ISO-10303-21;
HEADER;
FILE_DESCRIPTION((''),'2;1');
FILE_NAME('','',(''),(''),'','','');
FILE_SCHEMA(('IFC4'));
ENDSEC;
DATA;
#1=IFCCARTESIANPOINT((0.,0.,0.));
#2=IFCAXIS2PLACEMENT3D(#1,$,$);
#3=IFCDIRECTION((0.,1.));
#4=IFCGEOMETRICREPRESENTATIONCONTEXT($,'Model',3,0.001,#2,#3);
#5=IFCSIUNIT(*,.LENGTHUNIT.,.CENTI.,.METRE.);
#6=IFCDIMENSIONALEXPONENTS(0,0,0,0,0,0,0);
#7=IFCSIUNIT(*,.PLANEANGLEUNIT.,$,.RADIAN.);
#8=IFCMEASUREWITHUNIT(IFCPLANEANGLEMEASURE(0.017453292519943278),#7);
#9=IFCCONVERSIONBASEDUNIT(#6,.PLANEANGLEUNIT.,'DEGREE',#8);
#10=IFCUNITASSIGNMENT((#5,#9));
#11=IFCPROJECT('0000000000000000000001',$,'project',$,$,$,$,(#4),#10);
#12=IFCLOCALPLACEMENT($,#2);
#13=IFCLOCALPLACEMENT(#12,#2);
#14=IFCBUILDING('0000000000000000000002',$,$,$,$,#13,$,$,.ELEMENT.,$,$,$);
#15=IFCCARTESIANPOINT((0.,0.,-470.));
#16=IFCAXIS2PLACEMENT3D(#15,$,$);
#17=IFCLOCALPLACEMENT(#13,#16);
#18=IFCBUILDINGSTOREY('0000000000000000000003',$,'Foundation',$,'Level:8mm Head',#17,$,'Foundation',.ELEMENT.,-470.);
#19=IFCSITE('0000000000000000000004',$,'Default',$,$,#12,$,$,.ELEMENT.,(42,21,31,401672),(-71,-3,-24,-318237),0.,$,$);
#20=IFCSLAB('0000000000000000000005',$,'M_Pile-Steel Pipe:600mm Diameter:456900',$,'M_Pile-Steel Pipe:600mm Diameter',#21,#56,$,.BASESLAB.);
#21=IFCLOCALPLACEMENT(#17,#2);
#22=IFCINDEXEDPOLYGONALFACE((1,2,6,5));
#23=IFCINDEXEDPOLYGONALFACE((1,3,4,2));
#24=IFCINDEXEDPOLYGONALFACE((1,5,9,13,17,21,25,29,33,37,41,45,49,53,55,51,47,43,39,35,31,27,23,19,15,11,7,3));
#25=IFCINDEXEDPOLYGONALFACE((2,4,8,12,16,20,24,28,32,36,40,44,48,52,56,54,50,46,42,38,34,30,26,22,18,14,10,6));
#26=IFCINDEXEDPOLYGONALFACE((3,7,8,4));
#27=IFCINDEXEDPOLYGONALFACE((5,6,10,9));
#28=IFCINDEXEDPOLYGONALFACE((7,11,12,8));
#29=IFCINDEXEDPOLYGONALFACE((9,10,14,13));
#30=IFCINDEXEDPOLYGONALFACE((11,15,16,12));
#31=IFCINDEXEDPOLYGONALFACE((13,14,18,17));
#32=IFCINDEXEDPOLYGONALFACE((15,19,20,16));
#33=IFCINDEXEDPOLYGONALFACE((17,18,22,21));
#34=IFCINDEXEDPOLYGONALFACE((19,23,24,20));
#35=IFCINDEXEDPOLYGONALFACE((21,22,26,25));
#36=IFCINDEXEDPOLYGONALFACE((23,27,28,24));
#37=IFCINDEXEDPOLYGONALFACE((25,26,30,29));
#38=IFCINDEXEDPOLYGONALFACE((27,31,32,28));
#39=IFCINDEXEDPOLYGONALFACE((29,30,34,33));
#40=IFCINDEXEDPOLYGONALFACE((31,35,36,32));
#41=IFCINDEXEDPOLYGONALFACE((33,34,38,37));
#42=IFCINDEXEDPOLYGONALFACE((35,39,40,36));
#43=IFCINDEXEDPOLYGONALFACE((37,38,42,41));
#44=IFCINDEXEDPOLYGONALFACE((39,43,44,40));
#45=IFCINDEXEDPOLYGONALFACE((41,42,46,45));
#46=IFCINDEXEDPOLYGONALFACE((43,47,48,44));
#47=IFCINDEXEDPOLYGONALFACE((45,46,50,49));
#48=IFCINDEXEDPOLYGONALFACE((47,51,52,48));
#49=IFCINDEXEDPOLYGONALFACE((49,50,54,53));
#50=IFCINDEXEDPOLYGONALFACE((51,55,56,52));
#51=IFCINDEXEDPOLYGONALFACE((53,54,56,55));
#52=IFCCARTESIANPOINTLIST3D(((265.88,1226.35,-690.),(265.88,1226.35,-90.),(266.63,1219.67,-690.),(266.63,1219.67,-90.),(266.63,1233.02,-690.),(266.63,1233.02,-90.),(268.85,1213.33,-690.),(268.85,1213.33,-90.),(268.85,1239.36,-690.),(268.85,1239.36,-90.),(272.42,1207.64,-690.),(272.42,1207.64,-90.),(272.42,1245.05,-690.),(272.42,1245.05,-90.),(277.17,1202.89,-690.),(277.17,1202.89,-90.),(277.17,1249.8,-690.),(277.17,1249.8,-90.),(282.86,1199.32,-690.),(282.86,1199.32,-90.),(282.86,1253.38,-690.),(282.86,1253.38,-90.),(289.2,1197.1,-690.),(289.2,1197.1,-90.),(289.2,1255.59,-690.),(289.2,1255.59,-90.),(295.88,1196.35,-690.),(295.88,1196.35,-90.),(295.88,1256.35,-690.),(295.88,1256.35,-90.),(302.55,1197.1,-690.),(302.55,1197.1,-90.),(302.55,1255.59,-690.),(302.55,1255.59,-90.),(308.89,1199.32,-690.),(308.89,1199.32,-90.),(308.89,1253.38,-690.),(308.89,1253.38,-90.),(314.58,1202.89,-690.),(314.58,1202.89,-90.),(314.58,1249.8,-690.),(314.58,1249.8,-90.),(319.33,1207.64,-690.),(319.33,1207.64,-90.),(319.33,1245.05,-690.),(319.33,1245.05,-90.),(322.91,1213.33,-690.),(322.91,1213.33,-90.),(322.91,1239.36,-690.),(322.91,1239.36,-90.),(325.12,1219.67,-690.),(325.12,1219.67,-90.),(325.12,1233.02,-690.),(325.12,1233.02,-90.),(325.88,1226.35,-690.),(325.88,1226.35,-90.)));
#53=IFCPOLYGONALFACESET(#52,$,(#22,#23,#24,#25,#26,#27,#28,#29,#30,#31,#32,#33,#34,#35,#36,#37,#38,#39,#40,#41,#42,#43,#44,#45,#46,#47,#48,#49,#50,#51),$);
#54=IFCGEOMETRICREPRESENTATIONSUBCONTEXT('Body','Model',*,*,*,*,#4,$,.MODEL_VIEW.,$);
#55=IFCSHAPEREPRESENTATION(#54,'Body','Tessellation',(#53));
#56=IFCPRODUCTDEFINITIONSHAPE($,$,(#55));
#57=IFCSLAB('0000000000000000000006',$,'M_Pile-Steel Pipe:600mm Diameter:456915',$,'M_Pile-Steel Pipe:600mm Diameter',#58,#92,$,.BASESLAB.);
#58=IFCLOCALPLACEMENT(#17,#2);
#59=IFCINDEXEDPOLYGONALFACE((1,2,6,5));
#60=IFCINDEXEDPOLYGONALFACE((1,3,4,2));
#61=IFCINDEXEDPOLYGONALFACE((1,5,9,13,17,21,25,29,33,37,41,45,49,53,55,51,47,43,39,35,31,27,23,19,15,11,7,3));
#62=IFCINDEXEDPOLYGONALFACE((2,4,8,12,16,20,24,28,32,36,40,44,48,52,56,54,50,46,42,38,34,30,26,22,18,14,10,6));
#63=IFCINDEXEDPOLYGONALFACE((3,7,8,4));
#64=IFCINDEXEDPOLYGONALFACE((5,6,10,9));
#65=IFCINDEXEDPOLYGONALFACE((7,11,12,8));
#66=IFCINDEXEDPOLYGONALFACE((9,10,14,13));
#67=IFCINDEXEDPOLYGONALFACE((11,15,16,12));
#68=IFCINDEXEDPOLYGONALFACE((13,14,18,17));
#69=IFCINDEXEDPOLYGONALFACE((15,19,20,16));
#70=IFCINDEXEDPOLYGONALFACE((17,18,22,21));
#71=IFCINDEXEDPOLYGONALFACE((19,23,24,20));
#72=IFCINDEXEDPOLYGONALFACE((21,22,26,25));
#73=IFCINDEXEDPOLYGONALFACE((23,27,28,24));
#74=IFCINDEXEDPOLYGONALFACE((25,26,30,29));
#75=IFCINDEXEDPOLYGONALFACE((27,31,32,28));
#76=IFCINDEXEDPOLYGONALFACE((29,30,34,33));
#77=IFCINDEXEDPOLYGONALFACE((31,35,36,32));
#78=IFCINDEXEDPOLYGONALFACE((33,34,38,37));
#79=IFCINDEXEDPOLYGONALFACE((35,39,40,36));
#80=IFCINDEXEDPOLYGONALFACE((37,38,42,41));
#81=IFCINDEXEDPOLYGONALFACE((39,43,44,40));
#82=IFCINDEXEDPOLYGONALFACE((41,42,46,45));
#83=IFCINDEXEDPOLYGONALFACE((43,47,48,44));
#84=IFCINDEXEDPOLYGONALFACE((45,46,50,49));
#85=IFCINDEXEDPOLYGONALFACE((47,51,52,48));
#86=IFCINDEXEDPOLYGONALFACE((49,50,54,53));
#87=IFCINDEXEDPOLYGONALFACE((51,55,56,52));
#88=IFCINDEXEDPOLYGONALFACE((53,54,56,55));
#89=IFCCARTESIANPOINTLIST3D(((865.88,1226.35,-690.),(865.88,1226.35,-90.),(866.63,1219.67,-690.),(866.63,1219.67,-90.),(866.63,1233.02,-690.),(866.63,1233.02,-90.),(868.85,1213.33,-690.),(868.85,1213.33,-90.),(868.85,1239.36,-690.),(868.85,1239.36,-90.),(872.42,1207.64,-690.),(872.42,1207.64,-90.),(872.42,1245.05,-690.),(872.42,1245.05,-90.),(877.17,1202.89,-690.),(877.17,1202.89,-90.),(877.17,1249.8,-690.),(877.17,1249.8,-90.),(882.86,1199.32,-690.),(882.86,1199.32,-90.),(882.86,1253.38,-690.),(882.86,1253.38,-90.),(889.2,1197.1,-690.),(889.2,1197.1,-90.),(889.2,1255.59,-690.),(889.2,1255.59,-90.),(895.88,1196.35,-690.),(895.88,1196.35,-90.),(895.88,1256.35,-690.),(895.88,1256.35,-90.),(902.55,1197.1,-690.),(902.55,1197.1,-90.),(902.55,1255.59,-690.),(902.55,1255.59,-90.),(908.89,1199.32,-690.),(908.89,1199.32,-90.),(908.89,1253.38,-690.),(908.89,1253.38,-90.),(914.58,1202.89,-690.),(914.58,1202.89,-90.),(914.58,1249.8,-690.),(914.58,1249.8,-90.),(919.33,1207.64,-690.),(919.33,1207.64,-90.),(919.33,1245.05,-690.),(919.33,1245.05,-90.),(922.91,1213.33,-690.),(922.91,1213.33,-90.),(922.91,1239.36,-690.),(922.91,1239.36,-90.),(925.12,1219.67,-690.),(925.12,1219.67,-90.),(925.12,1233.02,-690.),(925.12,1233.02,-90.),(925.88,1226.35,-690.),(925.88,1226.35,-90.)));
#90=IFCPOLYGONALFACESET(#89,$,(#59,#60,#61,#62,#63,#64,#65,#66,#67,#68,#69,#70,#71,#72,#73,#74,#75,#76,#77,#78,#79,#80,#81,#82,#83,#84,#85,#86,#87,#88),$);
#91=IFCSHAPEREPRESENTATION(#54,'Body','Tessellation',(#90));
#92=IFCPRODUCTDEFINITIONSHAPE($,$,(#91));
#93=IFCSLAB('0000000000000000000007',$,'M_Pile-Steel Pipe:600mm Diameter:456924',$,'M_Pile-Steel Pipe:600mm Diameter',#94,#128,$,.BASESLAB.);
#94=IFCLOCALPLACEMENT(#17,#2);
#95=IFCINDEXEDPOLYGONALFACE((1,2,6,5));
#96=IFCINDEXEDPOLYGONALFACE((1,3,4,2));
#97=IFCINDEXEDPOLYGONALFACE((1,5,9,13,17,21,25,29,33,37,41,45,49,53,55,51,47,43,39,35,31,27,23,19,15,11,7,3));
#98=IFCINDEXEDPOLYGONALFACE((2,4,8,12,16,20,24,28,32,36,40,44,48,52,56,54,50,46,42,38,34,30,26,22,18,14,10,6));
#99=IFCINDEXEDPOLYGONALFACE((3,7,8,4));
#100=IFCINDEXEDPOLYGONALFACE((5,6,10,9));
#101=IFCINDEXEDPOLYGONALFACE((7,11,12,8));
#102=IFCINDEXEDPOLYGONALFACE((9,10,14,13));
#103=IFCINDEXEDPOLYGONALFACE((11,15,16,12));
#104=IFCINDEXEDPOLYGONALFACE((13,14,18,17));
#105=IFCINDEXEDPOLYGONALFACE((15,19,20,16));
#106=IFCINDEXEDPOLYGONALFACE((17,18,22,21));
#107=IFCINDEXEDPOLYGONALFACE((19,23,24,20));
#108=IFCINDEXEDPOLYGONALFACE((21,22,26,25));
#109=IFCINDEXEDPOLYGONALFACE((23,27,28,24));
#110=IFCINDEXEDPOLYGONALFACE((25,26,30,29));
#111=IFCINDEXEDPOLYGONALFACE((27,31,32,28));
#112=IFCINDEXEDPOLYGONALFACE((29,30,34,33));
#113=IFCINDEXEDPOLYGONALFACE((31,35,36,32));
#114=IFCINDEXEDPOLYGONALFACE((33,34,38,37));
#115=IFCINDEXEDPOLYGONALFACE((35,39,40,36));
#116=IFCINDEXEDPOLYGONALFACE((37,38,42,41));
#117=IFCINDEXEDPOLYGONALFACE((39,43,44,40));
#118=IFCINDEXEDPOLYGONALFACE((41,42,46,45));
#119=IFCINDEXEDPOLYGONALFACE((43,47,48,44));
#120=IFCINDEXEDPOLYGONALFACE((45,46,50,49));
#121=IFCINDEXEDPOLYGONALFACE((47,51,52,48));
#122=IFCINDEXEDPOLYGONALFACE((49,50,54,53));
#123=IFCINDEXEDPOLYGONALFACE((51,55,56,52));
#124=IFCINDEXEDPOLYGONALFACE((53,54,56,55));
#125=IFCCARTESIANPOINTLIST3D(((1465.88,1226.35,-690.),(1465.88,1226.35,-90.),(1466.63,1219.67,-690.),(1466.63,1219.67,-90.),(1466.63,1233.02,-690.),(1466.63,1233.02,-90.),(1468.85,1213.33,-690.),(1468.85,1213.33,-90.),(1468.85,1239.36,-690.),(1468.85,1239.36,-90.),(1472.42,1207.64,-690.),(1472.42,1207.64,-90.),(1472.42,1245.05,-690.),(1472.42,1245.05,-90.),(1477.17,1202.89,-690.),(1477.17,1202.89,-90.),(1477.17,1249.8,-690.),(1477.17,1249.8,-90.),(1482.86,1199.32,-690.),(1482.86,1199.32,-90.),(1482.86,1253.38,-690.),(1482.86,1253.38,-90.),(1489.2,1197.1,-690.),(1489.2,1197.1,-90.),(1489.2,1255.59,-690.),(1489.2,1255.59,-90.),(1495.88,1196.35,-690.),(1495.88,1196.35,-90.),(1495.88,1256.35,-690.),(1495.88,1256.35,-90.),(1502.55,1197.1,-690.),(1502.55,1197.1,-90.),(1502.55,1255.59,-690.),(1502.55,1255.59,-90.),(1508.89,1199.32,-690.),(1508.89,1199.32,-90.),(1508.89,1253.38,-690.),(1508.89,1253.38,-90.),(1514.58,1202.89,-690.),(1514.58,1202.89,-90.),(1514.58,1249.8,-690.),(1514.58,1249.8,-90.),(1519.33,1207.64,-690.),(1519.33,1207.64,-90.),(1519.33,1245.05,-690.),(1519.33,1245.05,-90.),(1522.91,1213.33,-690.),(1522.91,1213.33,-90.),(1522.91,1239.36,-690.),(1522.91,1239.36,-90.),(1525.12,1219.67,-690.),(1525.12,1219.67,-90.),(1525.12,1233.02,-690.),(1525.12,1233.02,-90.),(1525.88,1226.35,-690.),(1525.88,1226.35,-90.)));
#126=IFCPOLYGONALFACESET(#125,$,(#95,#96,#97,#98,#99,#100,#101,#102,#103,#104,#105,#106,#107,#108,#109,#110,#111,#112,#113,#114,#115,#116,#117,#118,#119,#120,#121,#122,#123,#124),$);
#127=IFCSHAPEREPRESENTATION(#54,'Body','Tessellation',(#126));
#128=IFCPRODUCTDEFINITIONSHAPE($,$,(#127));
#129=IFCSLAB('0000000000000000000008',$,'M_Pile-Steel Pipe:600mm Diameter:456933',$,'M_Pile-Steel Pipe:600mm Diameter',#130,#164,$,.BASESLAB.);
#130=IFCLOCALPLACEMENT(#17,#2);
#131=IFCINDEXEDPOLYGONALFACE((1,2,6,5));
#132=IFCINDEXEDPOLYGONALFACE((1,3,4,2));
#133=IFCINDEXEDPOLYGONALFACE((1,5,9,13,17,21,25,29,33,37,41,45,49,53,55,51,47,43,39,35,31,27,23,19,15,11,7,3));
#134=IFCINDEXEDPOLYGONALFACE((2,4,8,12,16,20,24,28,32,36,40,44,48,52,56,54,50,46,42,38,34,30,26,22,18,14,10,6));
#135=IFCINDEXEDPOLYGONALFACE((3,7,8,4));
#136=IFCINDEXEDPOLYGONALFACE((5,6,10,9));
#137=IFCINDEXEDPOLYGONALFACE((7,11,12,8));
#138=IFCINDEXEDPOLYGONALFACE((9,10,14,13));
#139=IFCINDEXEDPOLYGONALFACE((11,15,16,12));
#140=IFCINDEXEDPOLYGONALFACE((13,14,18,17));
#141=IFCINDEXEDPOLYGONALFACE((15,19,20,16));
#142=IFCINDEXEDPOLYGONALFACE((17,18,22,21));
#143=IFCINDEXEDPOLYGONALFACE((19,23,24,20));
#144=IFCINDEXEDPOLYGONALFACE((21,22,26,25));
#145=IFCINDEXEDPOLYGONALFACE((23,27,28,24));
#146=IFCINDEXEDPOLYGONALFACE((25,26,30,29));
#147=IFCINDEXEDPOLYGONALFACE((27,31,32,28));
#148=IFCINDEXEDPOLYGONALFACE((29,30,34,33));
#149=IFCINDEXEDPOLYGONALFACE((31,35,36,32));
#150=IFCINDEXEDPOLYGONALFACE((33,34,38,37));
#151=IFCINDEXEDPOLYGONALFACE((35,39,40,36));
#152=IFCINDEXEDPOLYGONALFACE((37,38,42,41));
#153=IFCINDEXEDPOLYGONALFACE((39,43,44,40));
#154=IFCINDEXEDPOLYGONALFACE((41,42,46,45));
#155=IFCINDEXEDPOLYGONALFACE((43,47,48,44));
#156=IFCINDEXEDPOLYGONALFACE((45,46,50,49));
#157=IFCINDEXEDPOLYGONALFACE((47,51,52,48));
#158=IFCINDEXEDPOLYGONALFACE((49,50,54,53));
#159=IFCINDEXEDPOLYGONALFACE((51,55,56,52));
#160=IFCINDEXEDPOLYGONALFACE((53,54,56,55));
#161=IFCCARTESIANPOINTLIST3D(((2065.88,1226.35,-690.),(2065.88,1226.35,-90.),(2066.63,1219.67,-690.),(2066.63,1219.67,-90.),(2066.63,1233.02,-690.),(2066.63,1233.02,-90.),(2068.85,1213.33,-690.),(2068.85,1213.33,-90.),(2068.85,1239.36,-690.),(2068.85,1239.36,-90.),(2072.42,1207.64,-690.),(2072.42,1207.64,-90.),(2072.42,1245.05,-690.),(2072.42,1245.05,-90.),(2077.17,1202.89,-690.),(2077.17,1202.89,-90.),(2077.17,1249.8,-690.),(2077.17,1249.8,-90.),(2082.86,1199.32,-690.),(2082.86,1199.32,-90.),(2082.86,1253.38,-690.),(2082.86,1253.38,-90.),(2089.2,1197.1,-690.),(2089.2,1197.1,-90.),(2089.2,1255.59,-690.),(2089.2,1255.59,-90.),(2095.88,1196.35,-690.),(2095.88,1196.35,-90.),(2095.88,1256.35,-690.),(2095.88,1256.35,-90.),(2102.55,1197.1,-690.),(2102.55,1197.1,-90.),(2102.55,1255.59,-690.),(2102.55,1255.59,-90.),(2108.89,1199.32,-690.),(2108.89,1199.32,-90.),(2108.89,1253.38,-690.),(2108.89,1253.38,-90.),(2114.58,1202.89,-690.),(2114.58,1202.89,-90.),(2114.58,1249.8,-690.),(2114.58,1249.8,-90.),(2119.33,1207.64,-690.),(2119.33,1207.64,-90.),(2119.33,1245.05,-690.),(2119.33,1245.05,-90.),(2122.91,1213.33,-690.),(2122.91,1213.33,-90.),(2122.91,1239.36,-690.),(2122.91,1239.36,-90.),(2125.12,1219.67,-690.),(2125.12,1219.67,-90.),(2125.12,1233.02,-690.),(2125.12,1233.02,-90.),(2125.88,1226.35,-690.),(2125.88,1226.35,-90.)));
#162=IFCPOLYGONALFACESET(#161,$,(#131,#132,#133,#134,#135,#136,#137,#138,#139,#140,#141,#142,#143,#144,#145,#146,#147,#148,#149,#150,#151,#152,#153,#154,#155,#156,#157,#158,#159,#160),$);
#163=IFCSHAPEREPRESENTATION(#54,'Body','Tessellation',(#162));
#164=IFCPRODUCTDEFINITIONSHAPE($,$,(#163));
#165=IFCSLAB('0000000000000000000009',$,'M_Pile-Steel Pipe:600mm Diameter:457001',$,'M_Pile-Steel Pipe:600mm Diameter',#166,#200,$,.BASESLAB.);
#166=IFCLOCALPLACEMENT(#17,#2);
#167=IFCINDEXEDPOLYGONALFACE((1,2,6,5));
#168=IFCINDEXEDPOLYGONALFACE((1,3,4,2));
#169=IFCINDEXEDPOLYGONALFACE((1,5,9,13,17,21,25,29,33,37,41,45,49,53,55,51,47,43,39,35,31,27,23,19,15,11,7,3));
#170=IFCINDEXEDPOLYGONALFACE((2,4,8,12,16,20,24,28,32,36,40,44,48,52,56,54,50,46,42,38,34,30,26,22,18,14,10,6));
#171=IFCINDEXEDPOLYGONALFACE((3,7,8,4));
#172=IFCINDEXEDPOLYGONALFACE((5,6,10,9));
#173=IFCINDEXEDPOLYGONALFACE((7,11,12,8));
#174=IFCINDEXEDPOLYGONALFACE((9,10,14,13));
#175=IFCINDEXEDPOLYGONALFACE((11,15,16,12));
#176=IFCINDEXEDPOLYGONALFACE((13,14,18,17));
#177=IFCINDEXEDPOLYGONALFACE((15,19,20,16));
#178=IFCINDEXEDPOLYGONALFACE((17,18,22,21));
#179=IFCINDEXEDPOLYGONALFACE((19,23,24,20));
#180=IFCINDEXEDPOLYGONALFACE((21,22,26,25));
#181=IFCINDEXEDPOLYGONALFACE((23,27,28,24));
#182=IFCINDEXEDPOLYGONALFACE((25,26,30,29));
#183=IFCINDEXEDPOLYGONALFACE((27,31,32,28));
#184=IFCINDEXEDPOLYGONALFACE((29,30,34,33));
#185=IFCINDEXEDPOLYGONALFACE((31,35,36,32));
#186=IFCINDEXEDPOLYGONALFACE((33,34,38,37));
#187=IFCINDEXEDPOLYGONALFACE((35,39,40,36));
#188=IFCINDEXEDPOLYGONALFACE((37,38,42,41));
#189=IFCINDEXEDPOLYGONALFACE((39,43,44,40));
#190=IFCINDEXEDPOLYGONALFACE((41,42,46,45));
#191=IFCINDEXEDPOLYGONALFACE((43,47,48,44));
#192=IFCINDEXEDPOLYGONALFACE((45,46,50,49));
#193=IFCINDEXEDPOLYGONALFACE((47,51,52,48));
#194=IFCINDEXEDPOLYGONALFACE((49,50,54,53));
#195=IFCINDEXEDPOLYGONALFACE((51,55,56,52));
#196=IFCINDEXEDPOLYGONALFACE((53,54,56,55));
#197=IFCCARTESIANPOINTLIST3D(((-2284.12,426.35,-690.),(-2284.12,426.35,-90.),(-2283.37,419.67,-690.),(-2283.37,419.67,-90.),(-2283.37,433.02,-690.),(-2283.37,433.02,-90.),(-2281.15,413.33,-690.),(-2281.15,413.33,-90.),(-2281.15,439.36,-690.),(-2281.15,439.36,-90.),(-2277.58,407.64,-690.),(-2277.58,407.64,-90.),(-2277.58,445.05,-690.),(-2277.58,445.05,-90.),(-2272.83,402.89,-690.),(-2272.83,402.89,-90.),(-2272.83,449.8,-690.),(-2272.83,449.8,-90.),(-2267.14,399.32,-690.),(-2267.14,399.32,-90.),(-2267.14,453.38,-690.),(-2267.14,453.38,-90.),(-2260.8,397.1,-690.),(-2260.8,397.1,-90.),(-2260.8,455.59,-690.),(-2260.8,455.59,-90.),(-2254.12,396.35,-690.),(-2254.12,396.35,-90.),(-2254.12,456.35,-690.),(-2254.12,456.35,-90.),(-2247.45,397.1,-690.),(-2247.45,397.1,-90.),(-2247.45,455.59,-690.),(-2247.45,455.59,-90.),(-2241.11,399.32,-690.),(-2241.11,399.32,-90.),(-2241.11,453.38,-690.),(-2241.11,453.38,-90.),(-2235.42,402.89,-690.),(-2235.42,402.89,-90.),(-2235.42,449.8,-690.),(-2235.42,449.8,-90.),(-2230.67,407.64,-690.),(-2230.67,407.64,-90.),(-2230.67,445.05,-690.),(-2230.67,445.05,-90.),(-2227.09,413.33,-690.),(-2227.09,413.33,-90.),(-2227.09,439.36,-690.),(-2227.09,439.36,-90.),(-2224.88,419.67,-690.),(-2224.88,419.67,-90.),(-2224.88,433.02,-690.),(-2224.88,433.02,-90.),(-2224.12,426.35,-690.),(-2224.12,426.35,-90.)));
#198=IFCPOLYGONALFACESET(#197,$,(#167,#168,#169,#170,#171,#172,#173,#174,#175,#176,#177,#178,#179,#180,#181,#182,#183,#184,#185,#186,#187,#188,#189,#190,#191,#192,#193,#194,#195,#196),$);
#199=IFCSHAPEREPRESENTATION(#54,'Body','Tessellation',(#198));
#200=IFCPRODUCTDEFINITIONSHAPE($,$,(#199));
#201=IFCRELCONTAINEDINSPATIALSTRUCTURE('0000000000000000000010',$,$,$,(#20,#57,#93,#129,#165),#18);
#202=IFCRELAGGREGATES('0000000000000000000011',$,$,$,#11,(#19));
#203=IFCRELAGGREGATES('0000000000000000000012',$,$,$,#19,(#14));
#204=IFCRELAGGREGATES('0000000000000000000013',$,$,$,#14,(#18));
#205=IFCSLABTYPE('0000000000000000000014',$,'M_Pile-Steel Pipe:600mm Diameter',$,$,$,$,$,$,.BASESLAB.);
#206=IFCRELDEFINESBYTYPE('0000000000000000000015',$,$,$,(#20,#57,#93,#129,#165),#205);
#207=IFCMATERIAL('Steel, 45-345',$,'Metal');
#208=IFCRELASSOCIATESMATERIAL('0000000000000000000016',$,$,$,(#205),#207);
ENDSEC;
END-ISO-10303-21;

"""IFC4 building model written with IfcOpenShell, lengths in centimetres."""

from ifc_helpers import new_model, entity, si_unit, converted_unit, direction, frame, origin, place, context, subcontext, project, spatial, arc, indexed_curve, outline, extrude, material, type_object, element, save


model = new_model("IFC4")

# Units and contexts
model_context = context("Model", 3, precision=0.001, world=origin(), true_north=direction((0.0, 1.0)))
body_context = subcontext(model_context, "Body", "Model", "MODEL_VIEW")
ifc_project = project(units=[si_unit("LENGTHUNIT", "METRE", prefix="CENTI"), converted_unit("PLANEANGLEUNIT", "DEGREE", entity("IfcPlaneAngleMeasure", 0.017453292519943278), si_unit("PLANEANGLEUNIT", "RADIAN"), dimensions=[0, 0, 0, 0, 0, 0, 0])], contexts=[model_context])

# Site, building, storey
site_placement = place(None, origin())
site = spatial("IfcSite", under=ifc_project, at=site_placement, Name="Default", CompositionType="ELEMENT", RefLatitude=(42, 21, 31, 401672), RefLongitude=(-71, -3, -24, -318237), RefElevation=0.0)
building_placement = place(site_placement, origin())
building = spatial("IfcBuilding", under=site, at=building_placement, CompositionType="ELEMENT")
storey_placement = place(building_placement, frame((0.0, 0.0, -470.0)))
storey = spatial("IfcBuildingStorey", under=building, at=storey_placement, Name="Foundation", ObjectType="Level:8mm Head", LongName="Foundation", CompositionType="ELEMENT", Elevation=-470.0)

# Slabs
ifc_material_1 = material(Name="Steel, 45-345", Category="Metal")
slab_type_1 = type_object("IfcSlabType", Name="M_Pile-Steel Pipe:600mm Diameter", PredefinedType="BASESLAB", material=ifc_material_1)
slab_1_placement = place(storey_placement, origin())
element("IfcSlab", 1, at=slab_1_placement, inside=storey, type_object=slab_type_1, Name="M_Pile-Steel Pipe:600mm Diameter:456900", ObjectType="M_Pile-Steel Pipe:600mm Diameter", PredefinedType="BASESLAB", context=body_context, shape_type="SweptSolid", body=[
    extrude(outline(indexed_curve([(-30.0, 0.0), (0.0, -30.0), (30.0, 0.0), (0.0, 30.0)], segments=[arc(1, 2, 3), arc(3, 4, 1)], self_intersect=False)), frame((295.88, 1226.35, -690.0)), (0.0, 0.0, 1.0), 600.0),
])
slab_2_placement = place(storey_placement, origin())
element("IfcSlab", 2, at=slab_2_placement, inside=storey, type_object=slab_type_1, Name="M_Pile-Steel Pipe:600mm Diameter:456915", ObjectType="M_Pile-Steel Pipe:600mm Diameter", PredefinedType="BASESLAB", context=body_context, shape_type="SweptSolid", body=[
    extrude(outline(indexed_curve([(-30.0, 0.0), (0.0, -30.0), (30.0, 0.0), (0.0, 30.0)], segments=[arc(1, 2, 3), arc(3, 4, 1)], self_intersect=False)), frame((895.88, 1226.35, -690.0)), (0.0, 0.0, 1.0), 600.0),
])
slab_3_placement = place(storey_placement, origin())
element("IfcSlab", 3, at=slab_3_placement, inside=storey, type_object=slab_type_1, Name="M_Pile-Steel Pipe:600mm Diameter:456924", ObjectType="M_Pile-Steel Pipe:600mm Diameter", PredefinedType="BASESLAB", context=body_context, shape_type="SweptSolid", body=[
    extrude(outline(indexed_curve([(-30.0, 0.0), (0.0, -30.0), (30.0, 0.0), (0.0, 30.0)], segments=[arc(1, 2, 3), arc(3, 4, 1)], self_intersect=False)), frame((1495.88, 1226.35, -690.0)), (0.0, 0.0, 1.0), 600.0),
])
slab_4_placement = place(storey_placement, origin())
element("IfcSlab", 4, at=slab_4_placement, inside=storey, type_object=slab_type_1, Name="M_Pile-Steel Pipe:600mm Diameter:456933", ObjectType="M_Pile-Steel Pipe:600mm Diameter", PredefinedType="BASESLAB", context=body_context, shape_type="SweptSolid", body=[
    extrude(outline(indexed_curve([(-30.0, 0.0), (0.0, -30.0), (30.0, 0.0), (0.0, 30.0)], segments=[arc(1, 2, 3), arc(3, 4, 1)], self_intersect=False)), frame((2095.88, 1226.35, -690.0)), (0.0, 0.0, 1.0), 600.0),
])
slab_5_placement = place(storey_placement, origin())
element("IfcSlab", 5, at=slab_5_placement, inside=storey, type_object=slab_type_1, Name="M_Pile-Steel Pipe:600mm Diameter:457001", ObjectType="M_Pile-Steel Pipe:600mm Diameter", PredefinedType="BASESLAB", context=body_context, shape_type="SweptSolid", body=[
    extrude(outline(indexed_curve([(-30.0, 0.0), (0.0, -30.0), (30.0, 0.0), (0.0, 30.0)], segments=[arc(1, 2, 3), arc(3, 4, 1)], self_intersect=False)), frame((-2254.12, 426.35, -690.0)), (0.0, 0.0, 1.0), 600.0),
])

save(model, "model.ifc")
